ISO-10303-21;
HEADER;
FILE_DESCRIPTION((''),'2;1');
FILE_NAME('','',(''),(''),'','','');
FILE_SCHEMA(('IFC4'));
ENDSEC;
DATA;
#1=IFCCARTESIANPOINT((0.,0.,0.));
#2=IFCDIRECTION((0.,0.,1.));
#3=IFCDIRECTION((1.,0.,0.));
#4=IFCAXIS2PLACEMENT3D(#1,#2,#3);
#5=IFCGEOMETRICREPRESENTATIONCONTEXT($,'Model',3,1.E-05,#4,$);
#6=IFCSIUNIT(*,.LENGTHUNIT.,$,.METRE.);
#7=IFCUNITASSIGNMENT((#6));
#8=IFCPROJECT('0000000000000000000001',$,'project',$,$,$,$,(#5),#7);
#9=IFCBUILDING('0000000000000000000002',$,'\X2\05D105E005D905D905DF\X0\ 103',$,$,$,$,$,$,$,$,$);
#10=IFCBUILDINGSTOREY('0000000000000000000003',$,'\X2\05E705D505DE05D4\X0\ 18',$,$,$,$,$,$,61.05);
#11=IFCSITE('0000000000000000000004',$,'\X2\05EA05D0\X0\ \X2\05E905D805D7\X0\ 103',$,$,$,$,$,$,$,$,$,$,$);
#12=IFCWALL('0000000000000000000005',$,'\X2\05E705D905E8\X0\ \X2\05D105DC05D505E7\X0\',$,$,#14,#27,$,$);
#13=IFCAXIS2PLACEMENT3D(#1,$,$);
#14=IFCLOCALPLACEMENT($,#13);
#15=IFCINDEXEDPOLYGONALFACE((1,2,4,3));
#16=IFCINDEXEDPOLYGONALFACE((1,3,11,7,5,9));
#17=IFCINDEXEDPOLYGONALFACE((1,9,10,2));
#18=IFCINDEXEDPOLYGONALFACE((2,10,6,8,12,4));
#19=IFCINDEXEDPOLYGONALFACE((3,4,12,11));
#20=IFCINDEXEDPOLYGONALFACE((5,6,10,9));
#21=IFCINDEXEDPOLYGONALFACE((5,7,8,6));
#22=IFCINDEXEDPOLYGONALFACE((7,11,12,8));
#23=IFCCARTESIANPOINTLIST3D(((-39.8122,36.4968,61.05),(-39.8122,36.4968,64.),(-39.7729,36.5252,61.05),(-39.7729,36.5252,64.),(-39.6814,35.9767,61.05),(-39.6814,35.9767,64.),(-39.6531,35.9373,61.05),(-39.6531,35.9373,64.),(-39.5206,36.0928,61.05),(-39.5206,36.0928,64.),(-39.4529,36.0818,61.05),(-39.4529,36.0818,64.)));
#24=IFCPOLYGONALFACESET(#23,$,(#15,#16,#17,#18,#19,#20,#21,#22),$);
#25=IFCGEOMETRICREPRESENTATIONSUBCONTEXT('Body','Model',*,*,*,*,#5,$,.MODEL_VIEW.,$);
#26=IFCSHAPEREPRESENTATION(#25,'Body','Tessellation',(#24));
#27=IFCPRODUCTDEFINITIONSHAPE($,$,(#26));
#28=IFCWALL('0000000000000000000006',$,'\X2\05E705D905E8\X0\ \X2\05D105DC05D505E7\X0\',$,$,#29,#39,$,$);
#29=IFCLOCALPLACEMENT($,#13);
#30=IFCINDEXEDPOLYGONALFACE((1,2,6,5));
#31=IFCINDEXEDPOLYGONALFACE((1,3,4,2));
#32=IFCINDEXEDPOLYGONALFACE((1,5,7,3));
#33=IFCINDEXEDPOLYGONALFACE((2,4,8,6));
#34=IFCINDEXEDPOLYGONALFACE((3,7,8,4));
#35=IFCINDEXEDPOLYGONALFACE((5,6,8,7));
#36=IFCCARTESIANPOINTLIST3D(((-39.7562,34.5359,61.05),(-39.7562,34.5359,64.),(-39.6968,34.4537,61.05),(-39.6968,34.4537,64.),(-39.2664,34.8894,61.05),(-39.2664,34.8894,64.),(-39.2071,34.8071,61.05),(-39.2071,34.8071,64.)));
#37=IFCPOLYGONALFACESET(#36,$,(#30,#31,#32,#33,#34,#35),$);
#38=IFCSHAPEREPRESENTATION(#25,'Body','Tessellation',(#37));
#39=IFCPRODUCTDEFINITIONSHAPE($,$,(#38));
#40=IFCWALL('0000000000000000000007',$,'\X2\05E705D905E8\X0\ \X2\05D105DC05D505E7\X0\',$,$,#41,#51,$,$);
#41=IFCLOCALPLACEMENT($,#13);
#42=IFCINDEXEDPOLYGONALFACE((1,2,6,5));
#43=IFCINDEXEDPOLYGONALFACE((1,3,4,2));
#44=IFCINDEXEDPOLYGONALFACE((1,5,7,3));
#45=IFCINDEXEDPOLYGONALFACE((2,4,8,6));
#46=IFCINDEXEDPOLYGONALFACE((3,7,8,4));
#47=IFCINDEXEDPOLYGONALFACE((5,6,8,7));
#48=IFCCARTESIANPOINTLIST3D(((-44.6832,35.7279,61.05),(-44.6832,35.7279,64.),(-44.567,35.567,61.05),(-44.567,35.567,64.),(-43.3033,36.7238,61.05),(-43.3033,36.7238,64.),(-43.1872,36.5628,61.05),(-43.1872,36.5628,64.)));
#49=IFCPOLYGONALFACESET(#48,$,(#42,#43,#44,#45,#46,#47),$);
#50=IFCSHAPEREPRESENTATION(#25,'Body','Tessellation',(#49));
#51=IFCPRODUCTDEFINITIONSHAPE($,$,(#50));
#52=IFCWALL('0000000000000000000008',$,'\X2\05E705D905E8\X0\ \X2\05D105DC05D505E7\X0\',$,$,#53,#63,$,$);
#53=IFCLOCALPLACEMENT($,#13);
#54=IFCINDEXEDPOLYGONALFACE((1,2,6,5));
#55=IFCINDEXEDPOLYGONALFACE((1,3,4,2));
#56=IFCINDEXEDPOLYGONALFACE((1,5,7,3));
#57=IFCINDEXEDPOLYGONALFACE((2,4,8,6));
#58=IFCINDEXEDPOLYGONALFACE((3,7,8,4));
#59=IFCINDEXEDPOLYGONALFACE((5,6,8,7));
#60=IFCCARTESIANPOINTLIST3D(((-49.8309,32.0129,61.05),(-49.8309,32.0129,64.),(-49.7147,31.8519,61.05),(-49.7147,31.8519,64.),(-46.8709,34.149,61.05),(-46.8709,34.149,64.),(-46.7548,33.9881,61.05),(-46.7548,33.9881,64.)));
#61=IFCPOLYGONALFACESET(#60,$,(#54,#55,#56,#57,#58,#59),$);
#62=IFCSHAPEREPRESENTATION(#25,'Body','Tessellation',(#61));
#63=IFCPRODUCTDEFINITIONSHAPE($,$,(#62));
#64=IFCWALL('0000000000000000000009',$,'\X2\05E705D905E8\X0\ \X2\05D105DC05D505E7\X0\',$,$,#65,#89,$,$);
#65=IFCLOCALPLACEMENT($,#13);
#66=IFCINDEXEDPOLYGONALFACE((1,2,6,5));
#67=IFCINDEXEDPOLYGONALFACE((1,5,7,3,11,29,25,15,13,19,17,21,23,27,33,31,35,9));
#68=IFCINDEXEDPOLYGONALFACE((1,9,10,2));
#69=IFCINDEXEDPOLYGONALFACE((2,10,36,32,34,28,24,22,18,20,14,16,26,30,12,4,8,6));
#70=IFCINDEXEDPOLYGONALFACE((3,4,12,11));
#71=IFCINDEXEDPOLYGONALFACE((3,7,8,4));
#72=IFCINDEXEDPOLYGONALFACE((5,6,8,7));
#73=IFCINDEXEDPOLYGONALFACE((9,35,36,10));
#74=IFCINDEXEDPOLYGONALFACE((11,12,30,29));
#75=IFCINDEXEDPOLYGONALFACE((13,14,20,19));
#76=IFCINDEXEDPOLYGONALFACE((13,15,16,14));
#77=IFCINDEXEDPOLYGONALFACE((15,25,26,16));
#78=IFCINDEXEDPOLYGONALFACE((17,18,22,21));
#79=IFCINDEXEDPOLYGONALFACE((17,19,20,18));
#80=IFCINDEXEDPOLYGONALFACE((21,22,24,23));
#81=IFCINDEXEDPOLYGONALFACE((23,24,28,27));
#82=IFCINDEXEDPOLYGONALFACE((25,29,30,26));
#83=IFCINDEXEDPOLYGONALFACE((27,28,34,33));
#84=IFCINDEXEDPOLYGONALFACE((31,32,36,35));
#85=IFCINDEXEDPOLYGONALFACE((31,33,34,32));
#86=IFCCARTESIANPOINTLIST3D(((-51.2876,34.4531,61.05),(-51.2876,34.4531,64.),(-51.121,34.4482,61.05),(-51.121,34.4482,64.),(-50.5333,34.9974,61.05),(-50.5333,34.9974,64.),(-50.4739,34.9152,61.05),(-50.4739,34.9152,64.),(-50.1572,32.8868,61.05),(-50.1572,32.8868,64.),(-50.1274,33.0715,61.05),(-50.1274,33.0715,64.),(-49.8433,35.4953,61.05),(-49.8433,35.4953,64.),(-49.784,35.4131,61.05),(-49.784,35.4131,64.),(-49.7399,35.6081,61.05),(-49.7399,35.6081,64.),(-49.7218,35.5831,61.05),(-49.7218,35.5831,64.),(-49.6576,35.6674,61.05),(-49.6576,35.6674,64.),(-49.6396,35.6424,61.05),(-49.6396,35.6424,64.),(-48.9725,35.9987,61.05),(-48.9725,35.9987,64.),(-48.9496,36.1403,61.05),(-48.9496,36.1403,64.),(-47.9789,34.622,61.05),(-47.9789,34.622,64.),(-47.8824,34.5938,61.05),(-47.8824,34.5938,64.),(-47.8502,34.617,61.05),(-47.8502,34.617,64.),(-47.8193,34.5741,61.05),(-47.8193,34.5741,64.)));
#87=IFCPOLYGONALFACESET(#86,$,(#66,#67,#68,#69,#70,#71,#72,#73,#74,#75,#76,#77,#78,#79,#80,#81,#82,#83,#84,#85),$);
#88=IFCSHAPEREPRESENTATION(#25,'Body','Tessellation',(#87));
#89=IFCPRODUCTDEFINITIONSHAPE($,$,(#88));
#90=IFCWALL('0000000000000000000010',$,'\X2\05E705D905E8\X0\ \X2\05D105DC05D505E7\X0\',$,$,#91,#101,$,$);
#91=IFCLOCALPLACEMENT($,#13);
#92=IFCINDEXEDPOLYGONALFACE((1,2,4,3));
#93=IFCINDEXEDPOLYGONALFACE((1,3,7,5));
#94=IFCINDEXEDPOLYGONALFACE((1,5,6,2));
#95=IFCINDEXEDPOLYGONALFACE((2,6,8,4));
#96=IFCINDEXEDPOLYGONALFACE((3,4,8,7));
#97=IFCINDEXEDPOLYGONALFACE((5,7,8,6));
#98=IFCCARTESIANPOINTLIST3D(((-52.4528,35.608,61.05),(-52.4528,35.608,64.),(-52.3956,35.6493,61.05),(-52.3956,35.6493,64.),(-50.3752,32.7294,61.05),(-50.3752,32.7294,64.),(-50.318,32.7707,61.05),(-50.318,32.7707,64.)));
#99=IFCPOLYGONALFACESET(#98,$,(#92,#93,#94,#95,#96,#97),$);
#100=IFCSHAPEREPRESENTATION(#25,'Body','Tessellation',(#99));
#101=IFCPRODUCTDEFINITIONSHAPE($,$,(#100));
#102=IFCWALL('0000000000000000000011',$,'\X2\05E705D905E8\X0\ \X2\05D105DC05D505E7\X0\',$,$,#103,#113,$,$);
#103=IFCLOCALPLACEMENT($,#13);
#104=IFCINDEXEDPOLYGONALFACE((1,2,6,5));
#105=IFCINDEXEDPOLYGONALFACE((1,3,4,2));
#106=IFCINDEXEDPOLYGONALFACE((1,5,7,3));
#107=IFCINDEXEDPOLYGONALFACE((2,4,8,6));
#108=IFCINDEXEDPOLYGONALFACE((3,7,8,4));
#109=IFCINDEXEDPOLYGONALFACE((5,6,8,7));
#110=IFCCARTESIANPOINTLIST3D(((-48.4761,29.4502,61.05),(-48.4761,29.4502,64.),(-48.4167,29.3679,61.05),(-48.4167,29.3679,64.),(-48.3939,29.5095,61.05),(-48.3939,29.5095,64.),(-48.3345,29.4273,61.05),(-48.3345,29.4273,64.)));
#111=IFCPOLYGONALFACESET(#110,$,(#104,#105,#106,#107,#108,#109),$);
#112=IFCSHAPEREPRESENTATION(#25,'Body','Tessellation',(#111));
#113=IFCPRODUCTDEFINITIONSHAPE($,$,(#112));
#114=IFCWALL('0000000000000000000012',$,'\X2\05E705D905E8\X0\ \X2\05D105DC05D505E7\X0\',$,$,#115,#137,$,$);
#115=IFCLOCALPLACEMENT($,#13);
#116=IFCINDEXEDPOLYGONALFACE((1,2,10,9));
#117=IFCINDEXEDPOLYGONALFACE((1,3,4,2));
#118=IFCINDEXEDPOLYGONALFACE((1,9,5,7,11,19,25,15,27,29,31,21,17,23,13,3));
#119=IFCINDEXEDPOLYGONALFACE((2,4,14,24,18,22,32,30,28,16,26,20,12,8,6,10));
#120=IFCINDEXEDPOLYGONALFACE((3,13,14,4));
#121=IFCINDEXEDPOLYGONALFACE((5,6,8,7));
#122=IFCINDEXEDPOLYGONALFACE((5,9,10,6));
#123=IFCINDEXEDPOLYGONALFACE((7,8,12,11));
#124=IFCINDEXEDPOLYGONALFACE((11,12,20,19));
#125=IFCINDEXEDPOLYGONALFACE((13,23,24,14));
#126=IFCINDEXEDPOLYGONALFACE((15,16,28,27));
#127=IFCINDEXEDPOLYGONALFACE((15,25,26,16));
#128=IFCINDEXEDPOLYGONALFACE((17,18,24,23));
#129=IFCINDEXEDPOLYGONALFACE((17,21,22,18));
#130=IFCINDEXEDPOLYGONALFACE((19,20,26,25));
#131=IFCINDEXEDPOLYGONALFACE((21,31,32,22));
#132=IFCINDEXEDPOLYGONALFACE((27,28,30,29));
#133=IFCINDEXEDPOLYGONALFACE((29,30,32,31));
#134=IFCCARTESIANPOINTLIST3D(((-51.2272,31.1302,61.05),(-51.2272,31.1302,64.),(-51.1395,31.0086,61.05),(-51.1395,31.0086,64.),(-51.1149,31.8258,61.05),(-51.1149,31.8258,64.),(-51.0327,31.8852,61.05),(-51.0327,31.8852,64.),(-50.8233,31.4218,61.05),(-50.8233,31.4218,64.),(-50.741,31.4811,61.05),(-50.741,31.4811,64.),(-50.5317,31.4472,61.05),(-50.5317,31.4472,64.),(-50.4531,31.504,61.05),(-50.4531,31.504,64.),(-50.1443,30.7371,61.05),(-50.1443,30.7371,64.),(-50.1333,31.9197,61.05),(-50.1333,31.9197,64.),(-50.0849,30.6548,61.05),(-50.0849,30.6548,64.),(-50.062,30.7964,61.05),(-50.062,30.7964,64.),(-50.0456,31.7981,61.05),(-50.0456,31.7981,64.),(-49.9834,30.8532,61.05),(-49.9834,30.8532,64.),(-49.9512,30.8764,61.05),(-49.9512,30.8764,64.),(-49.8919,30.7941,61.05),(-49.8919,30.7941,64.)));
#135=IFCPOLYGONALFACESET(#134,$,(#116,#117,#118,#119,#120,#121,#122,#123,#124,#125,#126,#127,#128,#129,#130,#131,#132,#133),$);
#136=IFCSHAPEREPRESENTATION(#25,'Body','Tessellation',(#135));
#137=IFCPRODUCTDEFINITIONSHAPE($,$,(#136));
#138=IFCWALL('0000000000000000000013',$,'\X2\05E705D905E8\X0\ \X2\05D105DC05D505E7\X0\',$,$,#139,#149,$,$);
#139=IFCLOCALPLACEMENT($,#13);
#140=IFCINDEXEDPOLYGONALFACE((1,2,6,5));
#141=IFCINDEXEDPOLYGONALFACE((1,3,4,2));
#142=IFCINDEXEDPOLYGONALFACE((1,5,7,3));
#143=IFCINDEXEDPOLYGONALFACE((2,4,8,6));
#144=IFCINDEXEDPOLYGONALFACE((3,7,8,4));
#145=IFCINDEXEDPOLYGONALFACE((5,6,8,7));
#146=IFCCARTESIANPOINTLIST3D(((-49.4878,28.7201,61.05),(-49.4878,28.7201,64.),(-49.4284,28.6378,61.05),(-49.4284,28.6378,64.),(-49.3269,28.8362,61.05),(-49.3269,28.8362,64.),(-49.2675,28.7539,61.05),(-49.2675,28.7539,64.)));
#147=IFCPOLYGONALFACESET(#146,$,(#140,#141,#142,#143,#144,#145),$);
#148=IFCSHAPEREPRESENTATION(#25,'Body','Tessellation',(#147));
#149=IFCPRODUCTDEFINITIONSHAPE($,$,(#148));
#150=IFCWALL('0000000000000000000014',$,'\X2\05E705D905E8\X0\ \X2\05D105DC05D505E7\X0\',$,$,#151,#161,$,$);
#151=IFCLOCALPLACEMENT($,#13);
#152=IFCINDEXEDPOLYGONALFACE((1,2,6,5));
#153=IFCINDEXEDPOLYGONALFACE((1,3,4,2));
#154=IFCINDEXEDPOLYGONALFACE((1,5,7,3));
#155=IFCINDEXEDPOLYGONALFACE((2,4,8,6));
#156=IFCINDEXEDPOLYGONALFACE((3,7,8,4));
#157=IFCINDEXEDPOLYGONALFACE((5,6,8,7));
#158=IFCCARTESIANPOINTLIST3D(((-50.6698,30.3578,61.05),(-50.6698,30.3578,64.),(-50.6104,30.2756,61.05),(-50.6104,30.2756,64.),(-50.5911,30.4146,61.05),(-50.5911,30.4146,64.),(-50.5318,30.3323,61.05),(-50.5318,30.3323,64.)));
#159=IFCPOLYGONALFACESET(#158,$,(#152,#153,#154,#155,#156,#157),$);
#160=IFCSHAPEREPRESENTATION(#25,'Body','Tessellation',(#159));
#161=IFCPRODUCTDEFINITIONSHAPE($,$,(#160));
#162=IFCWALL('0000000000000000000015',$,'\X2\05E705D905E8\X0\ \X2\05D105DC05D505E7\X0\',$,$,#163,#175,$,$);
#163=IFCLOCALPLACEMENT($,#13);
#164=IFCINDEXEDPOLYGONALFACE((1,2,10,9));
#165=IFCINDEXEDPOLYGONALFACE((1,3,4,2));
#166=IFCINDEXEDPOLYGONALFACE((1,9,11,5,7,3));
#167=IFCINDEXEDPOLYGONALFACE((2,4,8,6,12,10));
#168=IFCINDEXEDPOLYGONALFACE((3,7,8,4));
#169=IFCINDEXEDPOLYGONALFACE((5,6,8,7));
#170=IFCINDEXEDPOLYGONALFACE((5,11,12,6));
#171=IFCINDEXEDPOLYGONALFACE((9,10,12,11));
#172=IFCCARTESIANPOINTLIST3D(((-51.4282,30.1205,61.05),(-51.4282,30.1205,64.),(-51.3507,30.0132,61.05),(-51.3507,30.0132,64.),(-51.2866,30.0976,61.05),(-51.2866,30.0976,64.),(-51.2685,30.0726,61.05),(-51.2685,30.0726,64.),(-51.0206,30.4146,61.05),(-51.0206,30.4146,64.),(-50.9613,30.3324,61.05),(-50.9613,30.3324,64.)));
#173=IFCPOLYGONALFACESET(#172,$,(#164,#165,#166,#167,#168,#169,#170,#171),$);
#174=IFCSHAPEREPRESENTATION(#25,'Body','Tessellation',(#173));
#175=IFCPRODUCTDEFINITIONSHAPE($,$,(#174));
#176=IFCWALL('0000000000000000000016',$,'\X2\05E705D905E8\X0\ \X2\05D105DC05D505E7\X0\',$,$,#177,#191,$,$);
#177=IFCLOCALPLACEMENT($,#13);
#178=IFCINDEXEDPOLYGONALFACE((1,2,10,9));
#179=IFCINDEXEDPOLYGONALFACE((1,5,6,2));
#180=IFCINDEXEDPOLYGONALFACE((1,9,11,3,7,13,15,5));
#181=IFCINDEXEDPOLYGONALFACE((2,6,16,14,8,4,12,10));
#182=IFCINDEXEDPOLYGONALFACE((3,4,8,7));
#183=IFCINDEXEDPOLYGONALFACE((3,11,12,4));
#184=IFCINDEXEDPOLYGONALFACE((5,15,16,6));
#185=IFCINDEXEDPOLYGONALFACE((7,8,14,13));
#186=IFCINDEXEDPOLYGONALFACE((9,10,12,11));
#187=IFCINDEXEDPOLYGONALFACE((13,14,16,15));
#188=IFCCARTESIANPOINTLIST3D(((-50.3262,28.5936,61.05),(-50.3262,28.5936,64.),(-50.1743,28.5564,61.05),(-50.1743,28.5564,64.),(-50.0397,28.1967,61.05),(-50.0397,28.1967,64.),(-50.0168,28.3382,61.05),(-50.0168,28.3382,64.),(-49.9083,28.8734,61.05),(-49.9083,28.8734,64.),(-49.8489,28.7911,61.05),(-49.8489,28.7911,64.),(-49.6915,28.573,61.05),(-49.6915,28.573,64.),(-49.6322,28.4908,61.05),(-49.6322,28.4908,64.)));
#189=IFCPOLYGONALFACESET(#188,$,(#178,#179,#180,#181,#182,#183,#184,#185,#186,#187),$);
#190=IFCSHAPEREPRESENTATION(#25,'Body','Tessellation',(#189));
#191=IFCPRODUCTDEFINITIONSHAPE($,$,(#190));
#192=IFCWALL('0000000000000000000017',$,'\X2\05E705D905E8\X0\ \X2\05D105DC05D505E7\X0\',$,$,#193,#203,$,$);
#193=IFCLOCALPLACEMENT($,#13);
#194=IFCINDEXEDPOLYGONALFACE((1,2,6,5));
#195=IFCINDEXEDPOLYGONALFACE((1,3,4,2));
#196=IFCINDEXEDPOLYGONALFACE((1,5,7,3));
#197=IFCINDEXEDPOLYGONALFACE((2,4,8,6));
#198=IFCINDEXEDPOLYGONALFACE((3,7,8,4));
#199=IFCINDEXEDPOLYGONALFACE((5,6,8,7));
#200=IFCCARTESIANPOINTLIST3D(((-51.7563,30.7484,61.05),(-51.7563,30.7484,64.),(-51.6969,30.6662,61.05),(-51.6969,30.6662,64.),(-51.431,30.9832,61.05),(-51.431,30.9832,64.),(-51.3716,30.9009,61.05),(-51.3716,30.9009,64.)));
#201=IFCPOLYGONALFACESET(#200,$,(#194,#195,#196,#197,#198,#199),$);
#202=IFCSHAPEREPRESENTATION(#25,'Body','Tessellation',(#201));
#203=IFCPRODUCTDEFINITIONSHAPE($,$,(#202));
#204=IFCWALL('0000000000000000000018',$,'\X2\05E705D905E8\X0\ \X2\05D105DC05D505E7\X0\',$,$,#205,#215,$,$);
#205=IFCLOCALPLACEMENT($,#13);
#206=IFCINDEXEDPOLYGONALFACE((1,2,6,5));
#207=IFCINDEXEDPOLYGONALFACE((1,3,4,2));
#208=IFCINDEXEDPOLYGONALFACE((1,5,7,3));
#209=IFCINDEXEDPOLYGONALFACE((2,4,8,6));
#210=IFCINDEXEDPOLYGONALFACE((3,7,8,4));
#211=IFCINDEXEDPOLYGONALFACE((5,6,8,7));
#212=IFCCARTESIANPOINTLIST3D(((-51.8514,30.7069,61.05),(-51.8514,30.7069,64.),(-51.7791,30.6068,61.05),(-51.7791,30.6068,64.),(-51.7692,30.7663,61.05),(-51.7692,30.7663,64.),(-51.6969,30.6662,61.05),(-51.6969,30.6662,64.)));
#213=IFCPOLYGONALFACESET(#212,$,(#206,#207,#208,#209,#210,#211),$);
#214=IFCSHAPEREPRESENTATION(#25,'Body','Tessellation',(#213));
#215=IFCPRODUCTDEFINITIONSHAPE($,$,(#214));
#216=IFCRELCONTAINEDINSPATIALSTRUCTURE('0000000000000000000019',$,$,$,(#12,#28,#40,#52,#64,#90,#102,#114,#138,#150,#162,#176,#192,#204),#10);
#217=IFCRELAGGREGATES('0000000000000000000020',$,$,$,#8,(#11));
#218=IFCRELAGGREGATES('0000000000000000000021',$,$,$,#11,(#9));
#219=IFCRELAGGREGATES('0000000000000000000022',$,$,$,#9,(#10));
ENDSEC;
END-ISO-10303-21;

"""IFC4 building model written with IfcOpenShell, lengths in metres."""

from ifc_helpers import new_model, si_unit, frame, origin_with_axes, context, subcontext, project, spatial, polyline, outline, extrude, element, save


model = new_model("IFC4")

# Units and contexts
model_context = context("Model", 3, precision=1e-05, world=origin_with_axes())
body_context = subcontext(model_context, "Body", "Model", "MODEL_VIEW")
ifc_project = project(units=[si_unit("LENGTHUNIT", "METRE")], contexts=[model_context])

# Site, building, storey
site = spatial("IfcSite", under=ifc_project, Name="תא שטח 103")
building = spatial("IfcBuilding", under=site, Name="בניין 103")
storey = spatial("IfcBuildingStorey", under=building, Name="קומה 18", Elevation=61.05)

# Walls
element("IfcWall", 1, inside=storey, Name="קיר בלוק", context=body_context, shape_type="SweptSolid", body=[
    extrude(outline(polyline([(-39.6814, 35.9767), (-39.5206, 36.0928), (-39.8122, 36.4968), (-39.7729, 36.5252), (-39.4529, 36.0818), (-39.6531, 35.9373), (-39.6814, 35.9767)])), frame((0.0, 0.0, 61.05)), (0.0, 0.0, 1.0), 2.95),
])
element("IfcWall", 2, inside=storey, Name="קיר בלוק", context=body_context, shape_type="SweptSolid", body=[
    extrude(outline(polyline([(-39.2071, 34.8071), (-39.6968, 34.4537), (-39.7562, 34.5359), (-39.2664, 34.8894), (-39.2071, 34.8071)])), frame((0.0, 0.0, 61.05)), (0.0, 0.0, 1.0), 2.95),
])
element("IfcWall", 3, inside=storey, Name="קיר בלוק", context=body_context, shape_type="SweptSolid", body=[
    extrude(outline(polyline([(-44.567, 35.567), (-44.6832, 35.7279), (-43.3033, 36.7238), (-43.1872, 36.5628), (-44.567, 35.567)])), frame((0.0, 0.0, 61.05)), (0.0, 0.0, 1.0), 2.95),
])
element("IfcWall", 4, inside=storey, Name="קיר בלוק", context=body_context, shape_type="SweptSolid", body=[
    extrude(outline(polyline([(-49.7147, 31.8519), (-49.8309, 32.0129), (-46.8709, 34.149), (-46.7548, 33.9881), (-49.7147, 31.8519)])), frame((0.0, 0.0, 61.05)), (0.0, 0.0, 1.0), 2.95),
])
element("IfcWall", 5, inside=storey, Name="קיר בלוק", context=body_context, shape_type="SweptSolid", body=[
    extrude(outline(polyline([(-50.1572, 32.8868), (-51.2876, 34.4531), (-50.5333, 34.9974), (-50.4739, 34.9152), (-51.121, 34.4482), (-50.1274, 33.0715), (-47.9789, 34.622), (-48.9725, 35.9987), (-49.784, 35.4131), (-49.8433, 35.4953), (-49.7218, 35.5831), (-49.7399, 35.6081), (-49.6576, 35.6674), (-49.6396, 35.6424), (-48.9496, 36.1403), (-47.8502, 34.617), (-47.8824, 34.5938), (-47.8193, 34.5741), (-50.1572, 32.8868)])), frame((0.0, 0.0, 61.05)), (0.0, 0.0, 1.0), 2.95),
])
element("IfcWall", 6, inside=storey, Name="קיר בלוק", context=body_context, shape_type="SweptSolid", body=[
    extrude(outline(polyline([(-52.4528, 35.608), (-52.3956, 35.6493), (-50.318, 32.7707), (-50.3752, 32.7294), (-52.4528, 35.608)])), frame((0.0, 0.0, 61.05)), (0.0, 0.0, 1.0), 2.95),
])
element("IfcWall", 7, inside=storey, Name="קיר בלוק", context=body_context, shape_type="SweptSolid", body=[
    extrude(outline(polyline([(-48.3345, 29.4273), (-48.4167, 29.3679), (-48.4761, 29.4502), (-48.3939, 29.5095), (-48.3345, 29.4273)])), frame((0.0, 0.0, 61.05)), (0.0, 0.0, 1.0), 2.95),
])
element("IfcWall", 8, inside=storey, Name="קיר בלוק", context=body_context, shape_type="SweptSolid", body=[
    extrude(outline(polyline([(-50.062, 30.7964), (-50.5317, 31.4472), (-51.1395, 31.0086), (-51.2272, 31.1302), (-50.8233, 31.4218), (-51.1149, 31.8258), (-51.0327, 31.8852), (-50.741, 31.4811), (-50.1333, 31.9197), (-50.0456, 31.7981), (-50.4531, 31.504), (-49.9834, 30.8532), (-49.9512, 30.8764), (-49.8919, 30.7941), (-50.0849, 30.6548), (-50.1443, 30.7371), (-50.062, 30.7964)])), frame((0.0, 0.0, 61.05)), (0.0, 0.0, 1.0), 2.95),
])
element("IfcWall", 9, inside=storey, Name="קיר בלוק", context=body_context, shape_type="SweptSolid", body=[
    extrude(outline(polyline([(-49.3269, 28.8362), (-49.2675, 28.7539), (-49.4284, 28.6378), (-49.4878, 28.7201), (-49.3269, 28.8362)])), frame((0.0, 0.0, 61.05)), (0.0, 0.0, 1.0), 2.95),
])
element("IfcWall", 10, inside=storey, Name="קיר בלוק", context=body_context, shape_type="SweptSolid", body=[
    extrude(outline(polyline([(-50.5911, 30.4146), (-50.5318, 30.3323), (-50.6104, 30.2756), (-50.6698, 30.3578), (-50.5911, 30.4146)])), frame((0.0, 0.0, 61.05)), (0.0, 0.0, 1.0), 2.95),
])
element("IfcWall", 11, inside=storey, Name="קיר בלוק", context=body_context, shape_type="SweptSolid", body=[
    extrude(outline(polyline([(-51.3507, 30.0132), (-51.4282, 30.1205), (-51.0206, 30.4146), (-50.9613, 30.3324), (-51.2866, 30.0976), (-51.2685, 30.0726), (-51.3507, 30.0132)])), frame((0.0, 0.0, 61.05)), (0.0, 0.0, 1.0), 2.95),
])
element("IfcWall", 12, inside=storey, Name="קיר בלוק", context=body_context, shape_type="SweptSolid", body=[
    extrude(outline(polyline([(-50.0168, 28.3382), (-49.6915, 28.573), (-49.6322, 28.4908), (-50.0397, 28.1967), (-50.3262, 28.5936), (-49.9083, 28.8734), (-49.8489, 28.7911), (-50.1743, 28.5564), (-50.0168, 28.3382)])), frame((0.0, 0.0, 61.05)), (0.0, 0.0, 1.0), 2.95),
])
element("IfcWall", 13, inside=storey, Name="קיר בלוק", context=body_context, shape_type="SweptSolid", body=[
    extrude(outline(polyline([(-51.3716, 30.9009), (-51.6969, 30.6662), (-51.7563, 30.7484), (-51.431, 30.9832), (-51.3716, 30.9009)])), frame((0.0, 0.0, 61.05)), (0.0, 0.0, 1.0), 2.95),
])
element("IfcWall", 14, inside=storey, Name="קיר בלוק", context=body_context, shape_type="SweptSolid", body=[
    extrude(outline(polyline([(-51.7692, 30.7663), (-51.6969, 30.6662), (-51.7791, 30.6068), (-51.8514, 30.7069), (-51.7692, 30.7663)])), frame((0.0, 0.0, 61.05)), (0.0, 0.0, 1.0), 2.95),
])

save(model, "model.ifc")
